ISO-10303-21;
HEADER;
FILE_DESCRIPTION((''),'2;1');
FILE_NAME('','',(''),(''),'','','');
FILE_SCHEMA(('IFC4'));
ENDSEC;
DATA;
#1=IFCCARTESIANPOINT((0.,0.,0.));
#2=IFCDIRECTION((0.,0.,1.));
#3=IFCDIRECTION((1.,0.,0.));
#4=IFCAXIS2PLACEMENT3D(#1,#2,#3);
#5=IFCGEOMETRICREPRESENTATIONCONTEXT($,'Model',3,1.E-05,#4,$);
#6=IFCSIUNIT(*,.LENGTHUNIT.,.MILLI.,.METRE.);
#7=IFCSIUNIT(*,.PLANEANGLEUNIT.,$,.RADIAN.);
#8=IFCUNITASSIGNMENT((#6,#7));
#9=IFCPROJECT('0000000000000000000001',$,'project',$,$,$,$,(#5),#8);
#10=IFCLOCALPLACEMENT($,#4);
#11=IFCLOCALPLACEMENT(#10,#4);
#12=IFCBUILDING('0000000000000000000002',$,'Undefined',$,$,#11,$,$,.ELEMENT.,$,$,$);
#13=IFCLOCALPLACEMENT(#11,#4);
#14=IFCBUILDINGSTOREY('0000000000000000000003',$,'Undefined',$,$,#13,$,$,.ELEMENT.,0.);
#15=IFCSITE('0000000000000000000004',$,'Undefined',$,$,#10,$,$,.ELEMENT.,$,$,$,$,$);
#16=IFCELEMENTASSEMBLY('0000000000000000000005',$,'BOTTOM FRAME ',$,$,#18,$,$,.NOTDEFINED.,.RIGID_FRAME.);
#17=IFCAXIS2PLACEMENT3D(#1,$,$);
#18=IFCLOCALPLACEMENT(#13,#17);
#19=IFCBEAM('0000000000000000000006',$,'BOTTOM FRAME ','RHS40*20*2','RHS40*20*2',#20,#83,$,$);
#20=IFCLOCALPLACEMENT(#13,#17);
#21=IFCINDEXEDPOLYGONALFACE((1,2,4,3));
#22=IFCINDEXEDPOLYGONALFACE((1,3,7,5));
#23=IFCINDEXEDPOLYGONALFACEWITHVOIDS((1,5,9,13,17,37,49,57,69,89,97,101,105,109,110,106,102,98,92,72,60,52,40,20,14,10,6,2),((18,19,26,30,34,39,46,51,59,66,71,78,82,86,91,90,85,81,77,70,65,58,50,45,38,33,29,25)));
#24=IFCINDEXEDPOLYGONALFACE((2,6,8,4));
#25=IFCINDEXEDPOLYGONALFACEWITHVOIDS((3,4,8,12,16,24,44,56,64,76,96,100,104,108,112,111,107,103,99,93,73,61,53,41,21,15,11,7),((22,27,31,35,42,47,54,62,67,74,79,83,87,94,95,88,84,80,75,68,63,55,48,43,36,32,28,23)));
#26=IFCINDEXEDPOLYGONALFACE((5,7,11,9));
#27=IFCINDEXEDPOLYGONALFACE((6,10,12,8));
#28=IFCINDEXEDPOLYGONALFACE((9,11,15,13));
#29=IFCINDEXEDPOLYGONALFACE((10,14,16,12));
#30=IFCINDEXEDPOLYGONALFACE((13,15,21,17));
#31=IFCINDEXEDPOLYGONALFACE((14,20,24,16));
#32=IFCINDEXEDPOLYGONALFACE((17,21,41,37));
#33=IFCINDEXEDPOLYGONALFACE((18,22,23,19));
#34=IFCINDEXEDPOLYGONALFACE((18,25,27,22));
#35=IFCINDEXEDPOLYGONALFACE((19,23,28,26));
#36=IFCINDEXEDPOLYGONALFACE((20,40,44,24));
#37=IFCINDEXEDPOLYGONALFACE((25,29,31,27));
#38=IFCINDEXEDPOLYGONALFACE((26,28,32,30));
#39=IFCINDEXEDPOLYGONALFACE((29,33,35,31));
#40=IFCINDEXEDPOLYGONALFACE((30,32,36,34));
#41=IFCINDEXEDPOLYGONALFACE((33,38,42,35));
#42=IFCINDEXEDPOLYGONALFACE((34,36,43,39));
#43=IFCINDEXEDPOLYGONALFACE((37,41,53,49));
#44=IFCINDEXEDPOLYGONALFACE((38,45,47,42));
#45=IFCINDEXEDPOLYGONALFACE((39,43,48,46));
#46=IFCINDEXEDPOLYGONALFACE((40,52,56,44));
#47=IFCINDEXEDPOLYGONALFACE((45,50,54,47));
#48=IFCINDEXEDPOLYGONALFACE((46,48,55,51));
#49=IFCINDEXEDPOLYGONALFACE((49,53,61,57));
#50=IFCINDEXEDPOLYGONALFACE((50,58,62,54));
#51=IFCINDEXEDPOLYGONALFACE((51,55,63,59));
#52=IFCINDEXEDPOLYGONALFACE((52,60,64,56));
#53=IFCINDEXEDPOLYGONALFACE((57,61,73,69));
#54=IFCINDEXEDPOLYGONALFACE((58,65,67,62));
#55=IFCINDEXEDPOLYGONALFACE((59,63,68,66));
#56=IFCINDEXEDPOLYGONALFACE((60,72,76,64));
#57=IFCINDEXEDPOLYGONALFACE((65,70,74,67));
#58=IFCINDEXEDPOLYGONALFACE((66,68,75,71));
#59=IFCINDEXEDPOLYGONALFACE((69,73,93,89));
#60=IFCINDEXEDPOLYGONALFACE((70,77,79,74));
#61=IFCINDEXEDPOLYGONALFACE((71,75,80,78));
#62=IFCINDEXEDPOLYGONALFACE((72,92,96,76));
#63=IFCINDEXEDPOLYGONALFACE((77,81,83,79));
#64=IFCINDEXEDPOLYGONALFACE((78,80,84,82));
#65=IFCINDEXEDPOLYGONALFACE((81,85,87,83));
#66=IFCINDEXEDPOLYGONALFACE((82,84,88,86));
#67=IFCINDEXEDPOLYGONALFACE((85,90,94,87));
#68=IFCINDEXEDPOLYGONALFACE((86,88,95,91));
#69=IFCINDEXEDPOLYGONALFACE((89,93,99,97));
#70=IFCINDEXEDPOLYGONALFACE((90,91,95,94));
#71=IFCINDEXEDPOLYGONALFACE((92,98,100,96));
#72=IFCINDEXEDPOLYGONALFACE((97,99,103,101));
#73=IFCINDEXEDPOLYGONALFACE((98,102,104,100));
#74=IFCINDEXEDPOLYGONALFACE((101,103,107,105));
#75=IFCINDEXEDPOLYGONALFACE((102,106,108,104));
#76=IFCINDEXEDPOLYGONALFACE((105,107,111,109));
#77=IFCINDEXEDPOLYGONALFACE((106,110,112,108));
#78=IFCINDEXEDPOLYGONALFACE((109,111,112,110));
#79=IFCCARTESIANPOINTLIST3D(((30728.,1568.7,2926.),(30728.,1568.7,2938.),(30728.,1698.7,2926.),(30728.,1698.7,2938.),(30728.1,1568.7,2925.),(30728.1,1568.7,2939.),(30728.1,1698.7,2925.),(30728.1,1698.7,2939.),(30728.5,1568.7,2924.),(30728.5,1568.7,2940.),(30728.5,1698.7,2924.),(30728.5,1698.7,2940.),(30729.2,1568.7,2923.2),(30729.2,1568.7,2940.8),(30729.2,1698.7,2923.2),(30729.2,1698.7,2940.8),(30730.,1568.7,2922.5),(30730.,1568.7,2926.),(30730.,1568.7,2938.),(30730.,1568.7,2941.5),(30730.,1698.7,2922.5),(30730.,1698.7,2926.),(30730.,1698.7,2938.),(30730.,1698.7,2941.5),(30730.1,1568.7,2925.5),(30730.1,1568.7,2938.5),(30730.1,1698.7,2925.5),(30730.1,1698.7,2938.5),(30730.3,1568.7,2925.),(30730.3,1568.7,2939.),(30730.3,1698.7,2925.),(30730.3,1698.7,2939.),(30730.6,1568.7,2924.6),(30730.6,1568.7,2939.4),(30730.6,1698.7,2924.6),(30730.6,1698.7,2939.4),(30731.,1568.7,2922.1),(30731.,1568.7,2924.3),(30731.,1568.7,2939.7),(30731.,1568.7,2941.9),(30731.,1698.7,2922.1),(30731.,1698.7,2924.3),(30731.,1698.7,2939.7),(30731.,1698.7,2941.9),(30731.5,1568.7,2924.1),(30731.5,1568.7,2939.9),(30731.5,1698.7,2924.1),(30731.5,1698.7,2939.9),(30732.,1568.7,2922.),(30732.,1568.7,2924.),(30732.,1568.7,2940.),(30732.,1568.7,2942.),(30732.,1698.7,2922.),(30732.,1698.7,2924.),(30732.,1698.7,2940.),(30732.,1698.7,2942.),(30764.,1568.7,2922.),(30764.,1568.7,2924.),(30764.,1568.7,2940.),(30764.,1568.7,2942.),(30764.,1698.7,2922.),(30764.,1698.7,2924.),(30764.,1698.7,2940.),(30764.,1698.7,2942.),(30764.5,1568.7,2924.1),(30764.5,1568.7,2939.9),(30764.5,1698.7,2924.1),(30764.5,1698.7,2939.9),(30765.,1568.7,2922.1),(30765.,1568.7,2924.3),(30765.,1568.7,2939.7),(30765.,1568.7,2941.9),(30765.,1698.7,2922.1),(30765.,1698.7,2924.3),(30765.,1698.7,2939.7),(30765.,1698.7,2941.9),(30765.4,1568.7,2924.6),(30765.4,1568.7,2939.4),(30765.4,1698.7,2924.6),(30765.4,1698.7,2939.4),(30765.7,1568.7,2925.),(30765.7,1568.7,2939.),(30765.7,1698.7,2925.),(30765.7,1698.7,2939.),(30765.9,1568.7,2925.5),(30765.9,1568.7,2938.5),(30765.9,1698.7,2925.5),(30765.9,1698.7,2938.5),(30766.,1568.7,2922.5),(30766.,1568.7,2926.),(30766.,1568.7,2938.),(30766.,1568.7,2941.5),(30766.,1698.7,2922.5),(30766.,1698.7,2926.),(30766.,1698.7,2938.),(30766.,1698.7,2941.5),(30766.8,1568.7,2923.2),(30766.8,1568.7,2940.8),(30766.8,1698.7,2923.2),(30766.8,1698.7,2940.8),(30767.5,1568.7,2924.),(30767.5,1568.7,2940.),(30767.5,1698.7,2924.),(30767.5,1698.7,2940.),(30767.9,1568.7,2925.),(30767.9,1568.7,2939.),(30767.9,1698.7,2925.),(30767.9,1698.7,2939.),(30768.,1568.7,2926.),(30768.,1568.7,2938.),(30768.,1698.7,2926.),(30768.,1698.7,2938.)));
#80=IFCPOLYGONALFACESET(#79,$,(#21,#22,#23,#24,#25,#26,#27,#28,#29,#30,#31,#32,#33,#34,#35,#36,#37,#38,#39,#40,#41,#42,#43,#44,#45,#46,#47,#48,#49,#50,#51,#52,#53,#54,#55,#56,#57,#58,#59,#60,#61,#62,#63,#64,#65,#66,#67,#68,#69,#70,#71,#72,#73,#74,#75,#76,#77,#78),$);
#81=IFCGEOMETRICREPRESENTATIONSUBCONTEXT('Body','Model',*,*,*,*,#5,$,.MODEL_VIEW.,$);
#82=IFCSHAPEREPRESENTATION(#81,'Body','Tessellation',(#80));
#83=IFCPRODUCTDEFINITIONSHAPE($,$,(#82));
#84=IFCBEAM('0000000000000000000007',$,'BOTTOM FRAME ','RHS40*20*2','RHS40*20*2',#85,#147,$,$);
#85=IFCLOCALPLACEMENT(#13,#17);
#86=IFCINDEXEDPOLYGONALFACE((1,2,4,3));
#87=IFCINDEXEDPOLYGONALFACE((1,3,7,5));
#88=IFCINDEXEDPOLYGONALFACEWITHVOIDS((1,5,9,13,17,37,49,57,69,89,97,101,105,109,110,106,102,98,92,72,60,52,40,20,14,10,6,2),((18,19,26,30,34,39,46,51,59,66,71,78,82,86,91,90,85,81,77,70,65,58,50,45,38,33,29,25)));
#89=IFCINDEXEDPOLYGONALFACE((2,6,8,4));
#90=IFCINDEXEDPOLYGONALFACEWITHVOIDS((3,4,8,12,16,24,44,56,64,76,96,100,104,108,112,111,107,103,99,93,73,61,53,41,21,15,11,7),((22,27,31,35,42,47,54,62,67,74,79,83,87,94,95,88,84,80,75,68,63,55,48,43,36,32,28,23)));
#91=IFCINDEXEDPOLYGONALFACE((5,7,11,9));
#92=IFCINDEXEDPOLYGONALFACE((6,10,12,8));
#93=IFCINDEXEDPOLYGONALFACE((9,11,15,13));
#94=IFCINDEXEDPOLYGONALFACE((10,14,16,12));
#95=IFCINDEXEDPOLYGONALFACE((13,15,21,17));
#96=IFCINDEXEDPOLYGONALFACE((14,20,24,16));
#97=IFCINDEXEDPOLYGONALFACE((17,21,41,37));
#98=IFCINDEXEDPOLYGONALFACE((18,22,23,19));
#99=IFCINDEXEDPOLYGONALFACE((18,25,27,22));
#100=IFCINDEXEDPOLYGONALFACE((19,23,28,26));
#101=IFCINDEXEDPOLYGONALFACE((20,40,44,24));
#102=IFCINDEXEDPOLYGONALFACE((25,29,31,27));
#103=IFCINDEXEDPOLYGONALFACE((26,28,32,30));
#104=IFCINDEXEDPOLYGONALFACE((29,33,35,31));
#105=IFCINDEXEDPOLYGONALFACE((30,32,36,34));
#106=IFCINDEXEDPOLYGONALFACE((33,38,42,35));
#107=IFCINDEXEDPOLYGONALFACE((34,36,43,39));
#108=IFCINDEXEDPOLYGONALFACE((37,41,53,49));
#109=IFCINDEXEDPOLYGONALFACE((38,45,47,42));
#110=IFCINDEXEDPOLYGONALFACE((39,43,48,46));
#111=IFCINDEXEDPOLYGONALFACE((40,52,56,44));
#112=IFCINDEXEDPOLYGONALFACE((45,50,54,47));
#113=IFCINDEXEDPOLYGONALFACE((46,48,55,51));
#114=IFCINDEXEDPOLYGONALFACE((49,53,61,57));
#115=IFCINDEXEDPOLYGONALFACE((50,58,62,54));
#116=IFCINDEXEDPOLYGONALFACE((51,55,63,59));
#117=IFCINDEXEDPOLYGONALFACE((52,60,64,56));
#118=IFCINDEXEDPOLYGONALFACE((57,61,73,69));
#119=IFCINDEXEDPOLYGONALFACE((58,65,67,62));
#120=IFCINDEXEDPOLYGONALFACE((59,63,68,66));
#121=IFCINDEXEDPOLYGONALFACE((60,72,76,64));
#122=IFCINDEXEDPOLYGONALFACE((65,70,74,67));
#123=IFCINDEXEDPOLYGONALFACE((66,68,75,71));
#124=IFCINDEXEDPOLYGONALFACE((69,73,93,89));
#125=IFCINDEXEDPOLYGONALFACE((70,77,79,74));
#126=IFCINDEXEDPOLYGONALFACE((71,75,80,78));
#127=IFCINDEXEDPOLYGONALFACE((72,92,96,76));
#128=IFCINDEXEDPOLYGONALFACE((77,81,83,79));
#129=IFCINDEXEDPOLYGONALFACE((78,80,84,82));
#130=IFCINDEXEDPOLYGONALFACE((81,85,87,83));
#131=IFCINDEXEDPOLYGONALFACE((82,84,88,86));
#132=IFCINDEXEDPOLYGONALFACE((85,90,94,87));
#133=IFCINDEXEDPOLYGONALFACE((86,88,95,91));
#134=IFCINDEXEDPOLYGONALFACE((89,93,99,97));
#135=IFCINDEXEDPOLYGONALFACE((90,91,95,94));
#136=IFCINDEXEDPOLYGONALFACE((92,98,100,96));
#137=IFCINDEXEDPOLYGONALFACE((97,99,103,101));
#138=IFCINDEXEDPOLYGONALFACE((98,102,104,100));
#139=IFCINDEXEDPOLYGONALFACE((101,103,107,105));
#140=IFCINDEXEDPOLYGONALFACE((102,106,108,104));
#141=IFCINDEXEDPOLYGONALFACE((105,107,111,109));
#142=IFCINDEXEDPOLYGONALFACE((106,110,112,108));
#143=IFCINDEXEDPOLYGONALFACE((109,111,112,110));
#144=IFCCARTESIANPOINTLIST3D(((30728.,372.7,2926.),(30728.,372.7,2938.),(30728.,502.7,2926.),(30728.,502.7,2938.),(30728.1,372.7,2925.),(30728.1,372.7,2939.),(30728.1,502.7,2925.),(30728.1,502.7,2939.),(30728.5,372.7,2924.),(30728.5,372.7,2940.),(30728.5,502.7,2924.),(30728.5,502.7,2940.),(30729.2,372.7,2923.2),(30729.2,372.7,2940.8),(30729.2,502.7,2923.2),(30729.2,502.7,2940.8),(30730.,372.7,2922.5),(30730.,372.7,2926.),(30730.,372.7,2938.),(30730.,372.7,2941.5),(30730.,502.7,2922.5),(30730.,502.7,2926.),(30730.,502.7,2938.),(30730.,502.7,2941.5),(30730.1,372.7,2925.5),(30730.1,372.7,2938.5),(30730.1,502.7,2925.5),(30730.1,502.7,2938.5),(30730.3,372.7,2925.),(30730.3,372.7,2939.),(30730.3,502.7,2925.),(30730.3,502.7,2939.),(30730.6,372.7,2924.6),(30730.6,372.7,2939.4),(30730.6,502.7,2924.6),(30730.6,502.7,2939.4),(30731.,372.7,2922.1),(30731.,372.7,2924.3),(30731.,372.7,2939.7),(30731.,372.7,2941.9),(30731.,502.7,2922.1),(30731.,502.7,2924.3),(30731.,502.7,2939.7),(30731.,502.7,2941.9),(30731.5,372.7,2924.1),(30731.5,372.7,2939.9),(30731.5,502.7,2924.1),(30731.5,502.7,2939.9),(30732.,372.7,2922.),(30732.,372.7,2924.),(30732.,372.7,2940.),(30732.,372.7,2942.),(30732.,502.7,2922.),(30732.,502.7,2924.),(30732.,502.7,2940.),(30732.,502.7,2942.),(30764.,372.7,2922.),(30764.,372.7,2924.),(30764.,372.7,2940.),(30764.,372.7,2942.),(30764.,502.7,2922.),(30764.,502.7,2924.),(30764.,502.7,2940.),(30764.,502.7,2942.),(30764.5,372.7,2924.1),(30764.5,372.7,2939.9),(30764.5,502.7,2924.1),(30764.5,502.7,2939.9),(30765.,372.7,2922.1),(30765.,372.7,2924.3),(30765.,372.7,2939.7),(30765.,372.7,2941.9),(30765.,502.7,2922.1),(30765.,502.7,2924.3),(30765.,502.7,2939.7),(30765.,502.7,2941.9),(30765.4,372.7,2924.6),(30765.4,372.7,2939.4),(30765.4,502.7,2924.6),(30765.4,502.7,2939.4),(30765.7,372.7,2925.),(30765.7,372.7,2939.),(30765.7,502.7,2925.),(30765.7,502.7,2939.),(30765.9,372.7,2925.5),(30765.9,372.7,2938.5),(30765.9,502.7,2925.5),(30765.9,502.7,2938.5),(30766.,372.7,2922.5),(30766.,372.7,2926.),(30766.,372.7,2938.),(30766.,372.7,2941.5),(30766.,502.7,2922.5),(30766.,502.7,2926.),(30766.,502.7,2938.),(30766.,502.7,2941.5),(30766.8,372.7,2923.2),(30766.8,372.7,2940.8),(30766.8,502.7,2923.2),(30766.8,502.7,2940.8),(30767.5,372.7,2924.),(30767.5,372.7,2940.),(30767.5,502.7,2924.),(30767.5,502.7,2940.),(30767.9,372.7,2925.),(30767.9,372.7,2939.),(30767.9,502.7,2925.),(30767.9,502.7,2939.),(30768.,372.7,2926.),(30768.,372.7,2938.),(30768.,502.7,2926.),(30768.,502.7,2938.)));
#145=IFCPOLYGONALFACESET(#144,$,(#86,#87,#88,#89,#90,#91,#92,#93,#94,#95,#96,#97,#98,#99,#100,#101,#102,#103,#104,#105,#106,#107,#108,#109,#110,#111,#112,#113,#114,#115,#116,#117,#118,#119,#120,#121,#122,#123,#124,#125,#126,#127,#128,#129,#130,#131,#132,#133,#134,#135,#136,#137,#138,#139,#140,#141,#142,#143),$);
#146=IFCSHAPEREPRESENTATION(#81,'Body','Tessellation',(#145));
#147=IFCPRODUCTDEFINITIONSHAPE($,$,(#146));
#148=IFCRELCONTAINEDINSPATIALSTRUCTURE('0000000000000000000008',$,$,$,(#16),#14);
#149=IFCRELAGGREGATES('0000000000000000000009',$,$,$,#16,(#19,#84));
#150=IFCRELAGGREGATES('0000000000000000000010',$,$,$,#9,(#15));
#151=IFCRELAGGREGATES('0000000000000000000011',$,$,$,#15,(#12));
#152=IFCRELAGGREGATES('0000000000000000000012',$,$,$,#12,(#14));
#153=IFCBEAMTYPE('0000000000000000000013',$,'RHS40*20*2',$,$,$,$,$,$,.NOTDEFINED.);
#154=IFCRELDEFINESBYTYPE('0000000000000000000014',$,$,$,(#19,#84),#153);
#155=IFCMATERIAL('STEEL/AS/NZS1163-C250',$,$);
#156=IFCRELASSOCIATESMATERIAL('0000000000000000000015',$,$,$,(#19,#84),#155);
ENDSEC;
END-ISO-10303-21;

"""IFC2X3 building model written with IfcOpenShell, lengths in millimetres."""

from ifc_helpers import new_model, si_unit, frame, origin_with_axes, origin_2d_with_axis, place, context, subcontext, project, spatial, hollow_rectangle, extrude, material, type_object, element, aggregate, save


model = new_model("IFC2X3")

# Units and contexts
model_context = context("Model", 3, precision=1e-05, world=origin_with_axes())
body_context = subcontext(model_context, "Body", "Model", "MODEL_VIEW")
ifc_project = project(units=[si_unit("LENGTHUNIT", "METRE", prefix="MILLI"), si_unit("PLANEANGLEUNIT", "RADIAN")], contexts=[model_context])

# Site, building, storey
site_placement = place(None, origin_with_axes())
site = spatial("IfcSite", under=ifc_project, at=site_placement, Name="Undefined", CompositionType="ELEMENT")
building_placement = place(site_placement, origin_with_axes())
building = spatial("IfcBuilding", under=site, at=building_placement, Name="Undefined", CompositionType="ELEMENT")
storey_placement = place(building_placement, origin_with_axes())
storey = spatial("IfcBuildingStorey", under=building, at=storey_placement, Name="Undefined", CompositionType="ELEMENT", Elevation=0.0)

# Element assembly, beams
assembly_1_placement = place(storey_placement, origin_with_axes())
assembly_1 = element("IfcElementAssembly", 1, at=assembly_1_placement, inside=storey, Name="BOTTOM FRAME ", AssemblyPlace="NOTDEFINED", PredefinedType="RIGID_FRAME")
ifc_material_1 = material(Name="STEEL/AS/NZS1163-C250")
beam_type_1 = type_object("IfcBeamType", Name="RHS40*20*2", PredefinedType="NOTDEFINED")
beam_1_placement = place(assembly_1_placement, frame((30748.0, 1698.7, 2932.0), z_axis=(1.0, 0.0, 0.0), x_axis=(0.0, -1.0, 0.0)))
beam_1 = element("IfcBeam", 2, at=beam_1_placement, type_object=beam_type_1, material=ifc_material_1, Name="BOTTOM FRAME ", Description="RHS40*20*2", ObjectType="RHS40*20*2", context=body_context, shape_type="SweptSolid", body=[
    extrude(hollow_rectangle(XDim=20.0, YDim=40.0, WallThickness=2.0, InnerFilletRadius=2.0, OuterFilletRadius=4.0, at=origin_2d_with_axis()), frame((130.0, 0.0, 0.0), z_axis=(-1.0, 0.0, 0.0), x_axis=(0.0, -1.0, 0.0)), (0.0, 0.0, 1.0), 130.0),
])
beam_2_placement = place(assembly_1_placement, frame((30748.0, 502.7, 2932.0), z_axis=(1.0, 0.0, 0.0), x_axis=(0.0, -1.0, 0.0)))
beam_2 = element("IfcBeam", 3, at=beam_2_placement, type_object=beam_type_1, material=ifc_material_1, Name="BOTTOM FRAME ", Description="RHS40*20*2", ObjectType="RHS40*20*2", context=body_context, shape_type="SweptSolid", body=[
    extrude(hollow_rectangle(XDim=20.0, YDim=40.0, WallThickness=2.0, InnerFilletRadius=2.0, OuterFilletRadius=4.0, at=origin_2d_with_axis()), frame((130.0, 0.0, 0.0), z_axis=(-1.0, 0.0, 0.0), x_axis=(0.0, -1.0, 0.0)), (0.0, 0.0, 1.0), 130.0),
])
aggregate(assembly_1, [beam_1, beam_2])

save(model, "model.ifc")
